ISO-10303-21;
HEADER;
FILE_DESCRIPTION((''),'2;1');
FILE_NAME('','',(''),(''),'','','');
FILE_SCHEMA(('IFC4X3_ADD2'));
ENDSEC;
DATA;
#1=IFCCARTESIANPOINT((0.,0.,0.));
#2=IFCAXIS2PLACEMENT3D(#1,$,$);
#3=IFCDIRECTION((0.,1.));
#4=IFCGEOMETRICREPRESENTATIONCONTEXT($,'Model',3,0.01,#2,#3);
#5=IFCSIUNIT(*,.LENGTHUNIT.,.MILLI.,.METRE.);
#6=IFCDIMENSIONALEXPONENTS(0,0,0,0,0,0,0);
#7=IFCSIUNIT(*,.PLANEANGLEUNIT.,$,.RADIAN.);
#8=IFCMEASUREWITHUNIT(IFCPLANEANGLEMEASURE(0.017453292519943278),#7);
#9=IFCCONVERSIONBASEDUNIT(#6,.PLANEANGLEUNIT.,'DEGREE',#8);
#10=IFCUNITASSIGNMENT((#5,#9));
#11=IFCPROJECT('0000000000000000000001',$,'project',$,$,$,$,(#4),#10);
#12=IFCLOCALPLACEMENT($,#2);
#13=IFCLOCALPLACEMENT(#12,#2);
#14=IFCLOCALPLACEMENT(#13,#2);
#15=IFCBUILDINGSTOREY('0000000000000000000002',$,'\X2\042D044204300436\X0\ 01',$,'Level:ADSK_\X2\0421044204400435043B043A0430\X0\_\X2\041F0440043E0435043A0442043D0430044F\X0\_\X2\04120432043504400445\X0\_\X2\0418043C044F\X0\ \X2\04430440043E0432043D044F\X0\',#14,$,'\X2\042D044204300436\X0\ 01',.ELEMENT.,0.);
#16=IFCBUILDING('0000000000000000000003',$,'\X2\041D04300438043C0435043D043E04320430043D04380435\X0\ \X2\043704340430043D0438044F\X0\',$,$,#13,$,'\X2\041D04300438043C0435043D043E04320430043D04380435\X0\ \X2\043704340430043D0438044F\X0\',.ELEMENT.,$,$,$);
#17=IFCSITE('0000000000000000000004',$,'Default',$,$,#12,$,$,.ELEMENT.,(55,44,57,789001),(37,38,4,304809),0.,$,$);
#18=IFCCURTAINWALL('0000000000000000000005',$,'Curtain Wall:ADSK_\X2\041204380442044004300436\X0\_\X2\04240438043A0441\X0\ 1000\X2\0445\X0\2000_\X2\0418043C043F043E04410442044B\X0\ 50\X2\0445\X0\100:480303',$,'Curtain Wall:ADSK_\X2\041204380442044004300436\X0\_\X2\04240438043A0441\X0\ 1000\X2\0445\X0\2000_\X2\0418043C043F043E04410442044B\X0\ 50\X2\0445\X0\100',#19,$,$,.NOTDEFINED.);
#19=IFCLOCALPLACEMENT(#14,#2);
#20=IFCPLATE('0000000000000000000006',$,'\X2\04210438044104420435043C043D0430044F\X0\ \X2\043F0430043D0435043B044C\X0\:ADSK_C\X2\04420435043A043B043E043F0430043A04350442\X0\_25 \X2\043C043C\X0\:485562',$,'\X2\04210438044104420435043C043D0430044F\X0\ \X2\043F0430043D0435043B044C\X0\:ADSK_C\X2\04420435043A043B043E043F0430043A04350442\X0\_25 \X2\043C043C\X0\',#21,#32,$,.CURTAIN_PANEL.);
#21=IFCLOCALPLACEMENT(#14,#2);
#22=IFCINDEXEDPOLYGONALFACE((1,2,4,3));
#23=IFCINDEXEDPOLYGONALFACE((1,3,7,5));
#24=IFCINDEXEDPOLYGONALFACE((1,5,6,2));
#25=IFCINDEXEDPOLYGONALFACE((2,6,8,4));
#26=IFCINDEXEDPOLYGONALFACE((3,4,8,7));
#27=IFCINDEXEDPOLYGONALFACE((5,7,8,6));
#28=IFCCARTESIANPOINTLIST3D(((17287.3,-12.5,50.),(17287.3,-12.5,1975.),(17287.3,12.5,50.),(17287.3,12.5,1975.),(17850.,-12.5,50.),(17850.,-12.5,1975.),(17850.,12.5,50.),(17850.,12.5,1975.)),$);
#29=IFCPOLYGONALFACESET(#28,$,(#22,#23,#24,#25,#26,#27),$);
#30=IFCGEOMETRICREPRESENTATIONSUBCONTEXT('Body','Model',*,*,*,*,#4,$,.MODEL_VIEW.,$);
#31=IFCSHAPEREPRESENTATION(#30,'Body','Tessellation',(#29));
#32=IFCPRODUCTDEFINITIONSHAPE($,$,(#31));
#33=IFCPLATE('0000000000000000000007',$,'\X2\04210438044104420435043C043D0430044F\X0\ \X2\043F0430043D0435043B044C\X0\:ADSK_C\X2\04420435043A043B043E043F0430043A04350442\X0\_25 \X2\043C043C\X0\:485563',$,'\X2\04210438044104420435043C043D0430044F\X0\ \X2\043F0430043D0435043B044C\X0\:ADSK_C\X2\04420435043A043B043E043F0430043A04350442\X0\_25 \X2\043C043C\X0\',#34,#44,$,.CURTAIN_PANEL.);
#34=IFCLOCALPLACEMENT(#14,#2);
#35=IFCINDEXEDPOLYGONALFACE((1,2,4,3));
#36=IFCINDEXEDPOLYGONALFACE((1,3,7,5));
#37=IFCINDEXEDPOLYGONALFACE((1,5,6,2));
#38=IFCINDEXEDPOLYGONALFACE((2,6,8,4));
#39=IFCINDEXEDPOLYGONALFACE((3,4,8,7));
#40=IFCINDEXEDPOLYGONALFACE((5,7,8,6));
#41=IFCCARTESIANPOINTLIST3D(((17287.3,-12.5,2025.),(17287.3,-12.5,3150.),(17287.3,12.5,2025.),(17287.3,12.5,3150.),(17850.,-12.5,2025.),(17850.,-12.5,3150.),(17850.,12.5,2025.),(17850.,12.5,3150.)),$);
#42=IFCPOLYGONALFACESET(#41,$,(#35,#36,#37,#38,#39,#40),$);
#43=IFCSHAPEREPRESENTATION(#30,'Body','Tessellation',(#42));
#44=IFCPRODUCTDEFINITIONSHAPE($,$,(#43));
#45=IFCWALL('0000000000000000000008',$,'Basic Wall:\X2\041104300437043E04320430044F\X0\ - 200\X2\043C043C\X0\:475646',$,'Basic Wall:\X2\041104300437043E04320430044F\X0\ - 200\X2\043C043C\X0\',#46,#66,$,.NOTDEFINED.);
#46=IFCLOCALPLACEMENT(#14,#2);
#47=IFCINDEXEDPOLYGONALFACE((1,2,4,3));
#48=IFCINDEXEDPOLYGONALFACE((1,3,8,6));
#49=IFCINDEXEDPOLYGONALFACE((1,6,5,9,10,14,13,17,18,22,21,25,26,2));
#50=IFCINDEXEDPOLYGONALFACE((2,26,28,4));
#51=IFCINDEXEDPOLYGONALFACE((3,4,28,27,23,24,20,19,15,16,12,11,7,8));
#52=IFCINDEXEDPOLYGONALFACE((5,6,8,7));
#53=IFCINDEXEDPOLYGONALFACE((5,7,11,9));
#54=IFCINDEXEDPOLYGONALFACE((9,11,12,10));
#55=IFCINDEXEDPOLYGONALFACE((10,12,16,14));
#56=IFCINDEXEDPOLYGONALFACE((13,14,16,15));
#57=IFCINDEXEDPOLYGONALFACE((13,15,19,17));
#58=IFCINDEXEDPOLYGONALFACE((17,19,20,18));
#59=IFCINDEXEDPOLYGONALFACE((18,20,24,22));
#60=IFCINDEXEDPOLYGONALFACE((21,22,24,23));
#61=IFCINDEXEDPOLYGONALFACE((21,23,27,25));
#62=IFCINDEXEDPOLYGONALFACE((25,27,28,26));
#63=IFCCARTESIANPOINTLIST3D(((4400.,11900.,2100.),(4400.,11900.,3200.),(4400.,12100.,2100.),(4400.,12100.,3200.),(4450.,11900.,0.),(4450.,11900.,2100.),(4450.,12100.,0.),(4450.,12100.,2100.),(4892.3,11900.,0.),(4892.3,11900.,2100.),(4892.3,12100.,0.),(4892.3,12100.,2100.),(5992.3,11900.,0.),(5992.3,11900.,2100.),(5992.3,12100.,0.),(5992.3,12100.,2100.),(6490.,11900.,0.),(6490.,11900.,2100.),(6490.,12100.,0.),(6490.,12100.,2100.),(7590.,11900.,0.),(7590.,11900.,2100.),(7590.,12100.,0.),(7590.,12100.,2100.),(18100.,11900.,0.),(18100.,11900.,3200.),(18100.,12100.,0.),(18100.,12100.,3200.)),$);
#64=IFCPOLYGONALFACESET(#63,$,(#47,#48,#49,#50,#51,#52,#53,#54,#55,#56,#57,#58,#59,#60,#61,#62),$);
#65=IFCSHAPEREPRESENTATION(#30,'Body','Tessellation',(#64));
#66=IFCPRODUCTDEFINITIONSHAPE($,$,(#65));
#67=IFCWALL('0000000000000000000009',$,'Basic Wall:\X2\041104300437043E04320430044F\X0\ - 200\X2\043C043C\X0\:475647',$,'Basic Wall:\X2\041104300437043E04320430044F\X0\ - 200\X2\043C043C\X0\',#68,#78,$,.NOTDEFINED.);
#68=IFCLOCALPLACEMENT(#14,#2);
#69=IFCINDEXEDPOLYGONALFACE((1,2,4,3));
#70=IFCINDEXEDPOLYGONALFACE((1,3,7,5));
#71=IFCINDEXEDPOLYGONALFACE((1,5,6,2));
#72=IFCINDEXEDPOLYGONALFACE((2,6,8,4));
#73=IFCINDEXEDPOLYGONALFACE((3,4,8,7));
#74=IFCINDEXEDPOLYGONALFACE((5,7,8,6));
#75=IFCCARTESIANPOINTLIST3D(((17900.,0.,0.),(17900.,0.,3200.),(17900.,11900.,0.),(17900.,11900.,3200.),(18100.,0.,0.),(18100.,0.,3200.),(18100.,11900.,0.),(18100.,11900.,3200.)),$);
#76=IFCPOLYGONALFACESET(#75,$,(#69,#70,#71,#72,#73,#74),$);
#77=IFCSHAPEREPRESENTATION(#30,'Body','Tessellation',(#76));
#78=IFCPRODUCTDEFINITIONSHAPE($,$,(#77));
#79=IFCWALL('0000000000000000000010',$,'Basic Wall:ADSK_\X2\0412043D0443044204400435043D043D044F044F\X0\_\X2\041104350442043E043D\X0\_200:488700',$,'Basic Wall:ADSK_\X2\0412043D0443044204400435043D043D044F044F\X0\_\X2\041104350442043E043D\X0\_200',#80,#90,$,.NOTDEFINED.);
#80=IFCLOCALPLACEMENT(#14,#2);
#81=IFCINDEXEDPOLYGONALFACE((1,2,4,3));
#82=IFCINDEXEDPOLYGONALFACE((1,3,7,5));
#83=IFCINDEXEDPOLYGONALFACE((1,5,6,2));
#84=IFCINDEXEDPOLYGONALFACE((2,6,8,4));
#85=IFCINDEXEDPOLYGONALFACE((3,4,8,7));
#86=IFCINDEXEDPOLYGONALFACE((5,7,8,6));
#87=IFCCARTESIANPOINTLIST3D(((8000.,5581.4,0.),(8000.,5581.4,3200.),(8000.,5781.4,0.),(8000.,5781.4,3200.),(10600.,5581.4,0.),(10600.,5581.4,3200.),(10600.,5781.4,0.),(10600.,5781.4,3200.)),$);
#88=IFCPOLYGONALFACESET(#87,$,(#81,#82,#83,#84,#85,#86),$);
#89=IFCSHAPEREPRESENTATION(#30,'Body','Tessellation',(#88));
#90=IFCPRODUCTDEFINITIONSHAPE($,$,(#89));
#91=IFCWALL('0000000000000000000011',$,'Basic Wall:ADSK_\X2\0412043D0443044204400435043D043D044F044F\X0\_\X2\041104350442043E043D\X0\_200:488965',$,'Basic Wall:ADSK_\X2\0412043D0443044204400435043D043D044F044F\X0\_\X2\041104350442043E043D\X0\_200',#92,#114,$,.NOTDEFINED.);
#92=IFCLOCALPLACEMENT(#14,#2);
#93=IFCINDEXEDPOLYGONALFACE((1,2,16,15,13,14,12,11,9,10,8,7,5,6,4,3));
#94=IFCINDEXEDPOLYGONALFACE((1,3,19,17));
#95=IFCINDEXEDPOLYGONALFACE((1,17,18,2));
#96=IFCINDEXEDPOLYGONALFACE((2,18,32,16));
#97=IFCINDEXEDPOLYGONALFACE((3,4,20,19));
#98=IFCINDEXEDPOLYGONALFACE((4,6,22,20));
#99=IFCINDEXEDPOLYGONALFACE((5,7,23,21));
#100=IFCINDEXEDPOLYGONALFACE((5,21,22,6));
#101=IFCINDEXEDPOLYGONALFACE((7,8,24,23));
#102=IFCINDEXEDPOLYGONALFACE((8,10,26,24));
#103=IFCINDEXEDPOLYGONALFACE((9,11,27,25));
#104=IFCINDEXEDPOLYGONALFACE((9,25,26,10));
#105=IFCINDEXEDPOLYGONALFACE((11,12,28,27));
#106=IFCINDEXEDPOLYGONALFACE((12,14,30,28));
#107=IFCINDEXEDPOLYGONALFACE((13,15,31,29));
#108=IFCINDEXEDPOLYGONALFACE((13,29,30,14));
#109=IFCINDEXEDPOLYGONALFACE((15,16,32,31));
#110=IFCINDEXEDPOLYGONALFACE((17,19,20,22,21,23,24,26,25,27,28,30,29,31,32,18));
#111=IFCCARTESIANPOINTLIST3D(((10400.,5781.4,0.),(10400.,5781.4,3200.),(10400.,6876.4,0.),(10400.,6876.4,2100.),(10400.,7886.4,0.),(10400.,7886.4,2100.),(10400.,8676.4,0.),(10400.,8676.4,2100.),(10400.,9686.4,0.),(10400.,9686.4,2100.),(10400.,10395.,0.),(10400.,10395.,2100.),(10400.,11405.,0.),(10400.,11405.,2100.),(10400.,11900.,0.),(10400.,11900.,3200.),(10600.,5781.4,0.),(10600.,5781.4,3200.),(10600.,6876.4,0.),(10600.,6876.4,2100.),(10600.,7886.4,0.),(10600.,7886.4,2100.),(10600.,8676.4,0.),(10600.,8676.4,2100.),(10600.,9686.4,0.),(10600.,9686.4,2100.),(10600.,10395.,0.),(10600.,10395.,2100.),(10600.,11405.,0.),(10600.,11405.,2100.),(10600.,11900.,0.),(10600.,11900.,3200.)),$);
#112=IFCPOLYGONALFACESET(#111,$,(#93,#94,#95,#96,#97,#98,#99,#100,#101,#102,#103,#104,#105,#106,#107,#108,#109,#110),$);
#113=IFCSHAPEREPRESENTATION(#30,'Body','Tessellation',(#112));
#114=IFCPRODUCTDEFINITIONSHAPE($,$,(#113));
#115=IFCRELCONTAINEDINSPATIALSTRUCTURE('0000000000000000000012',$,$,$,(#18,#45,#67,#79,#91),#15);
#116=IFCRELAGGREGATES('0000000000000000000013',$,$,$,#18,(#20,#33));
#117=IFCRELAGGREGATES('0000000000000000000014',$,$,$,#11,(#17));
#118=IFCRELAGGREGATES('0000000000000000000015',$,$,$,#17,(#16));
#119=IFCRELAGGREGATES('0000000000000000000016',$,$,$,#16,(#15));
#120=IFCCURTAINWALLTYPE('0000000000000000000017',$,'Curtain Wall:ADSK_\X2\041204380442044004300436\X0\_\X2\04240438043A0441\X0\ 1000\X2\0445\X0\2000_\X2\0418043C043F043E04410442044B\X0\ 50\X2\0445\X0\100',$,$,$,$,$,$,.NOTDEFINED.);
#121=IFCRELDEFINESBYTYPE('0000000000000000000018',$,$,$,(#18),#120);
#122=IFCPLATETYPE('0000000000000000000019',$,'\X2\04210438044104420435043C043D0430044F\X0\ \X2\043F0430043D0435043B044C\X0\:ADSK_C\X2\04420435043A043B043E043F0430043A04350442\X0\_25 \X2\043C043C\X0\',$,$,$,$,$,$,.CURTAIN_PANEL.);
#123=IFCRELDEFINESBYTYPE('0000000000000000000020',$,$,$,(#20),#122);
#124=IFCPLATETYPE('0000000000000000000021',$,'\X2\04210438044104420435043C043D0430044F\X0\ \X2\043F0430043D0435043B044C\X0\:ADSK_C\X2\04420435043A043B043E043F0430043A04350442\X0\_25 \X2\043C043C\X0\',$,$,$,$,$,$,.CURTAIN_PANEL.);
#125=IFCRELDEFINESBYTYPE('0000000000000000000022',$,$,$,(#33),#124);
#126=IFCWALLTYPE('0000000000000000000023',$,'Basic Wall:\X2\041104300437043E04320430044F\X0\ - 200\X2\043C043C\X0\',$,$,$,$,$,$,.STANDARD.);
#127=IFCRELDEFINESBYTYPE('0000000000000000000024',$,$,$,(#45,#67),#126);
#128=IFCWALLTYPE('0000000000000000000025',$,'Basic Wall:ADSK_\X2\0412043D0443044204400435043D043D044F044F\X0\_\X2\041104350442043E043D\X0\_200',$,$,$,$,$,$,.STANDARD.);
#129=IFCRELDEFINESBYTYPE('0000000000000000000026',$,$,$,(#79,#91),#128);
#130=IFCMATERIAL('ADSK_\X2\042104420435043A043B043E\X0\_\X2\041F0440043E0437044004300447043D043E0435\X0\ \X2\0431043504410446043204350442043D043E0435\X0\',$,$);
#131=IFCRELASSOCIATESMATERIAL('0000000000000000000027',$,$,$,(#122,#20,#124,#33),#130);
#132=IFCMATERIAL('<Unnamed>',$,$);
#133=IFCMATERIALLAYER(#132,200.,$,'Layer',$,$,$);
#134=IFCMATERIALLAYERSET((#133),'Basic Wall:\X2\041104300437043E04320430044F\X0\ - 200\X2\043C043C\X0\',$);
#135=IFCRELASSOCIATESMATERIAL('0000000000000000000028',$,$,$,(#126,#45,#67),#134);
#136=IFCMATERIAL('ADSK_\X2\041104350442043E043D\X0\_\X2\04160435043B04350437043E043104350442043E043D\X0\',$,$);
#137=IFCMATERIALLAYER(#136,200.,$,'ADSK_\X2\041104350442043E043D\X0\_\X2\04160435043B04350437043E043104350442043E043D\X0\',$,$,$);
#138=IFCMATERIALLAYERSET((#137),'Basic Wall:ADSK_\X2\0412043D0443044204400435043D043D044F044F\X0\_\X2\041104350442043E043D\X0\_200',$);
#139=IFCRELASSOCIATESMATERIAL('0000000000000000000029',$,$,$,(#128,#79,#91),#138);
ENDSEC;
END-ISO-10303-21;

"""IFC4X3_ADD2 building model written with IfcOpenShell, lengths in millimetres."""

from ifc_helpers import new_model, entity, si_unit, converted_unit, direction, frame, frame_2d, origin, origin_2d_with_axis, place, context, subcontext, project, spatial, rectangle, extrude, source, transform, mapped, material, layer, layer_set, type_object, type_shapes, element, aggregate, save


model = new_model("IFC4X3_ADD2")

# Units and contexts
model_context = context("Model", 3, precision=0.01, world=origin(), true_north=direction((0.0, 1.0)))
body_context = subcontext(model_context, "Body", "Model", "MODEL_VIEW")
ifc_project = project(units=[si_unit("LENGTHUNIT", "METRE", prefix="MILLI"), converted_unit("PLANEANGLEUNIT", "DEGREE", entity("IfcPlaneAngleMeasure", 0.017453292519943278), si_unit("PLANEANGLEUNIT", "RADIAN"), dimensions=[0, 0, 0, 0, 0, 0, 0])], contexts=[model_context])

# Site, building, storey
site_placement = place(None, origin())
site = spatial("IfcSite", under=ifc_project, at=site_placement, Name="Default", CompositionType="ELEMENT", RefLatitude=(55, 44, 57, 789001), RefLongitude=(37, 38, 4, 304809), RefElevation=0.0)
building_placement = place(site_placement, origin())
building = spatial("IfcBuilding", under=site, at=building_placement, Name="Наименование здания", LongName="Наименование здания", CompositionType="ELEMENT")
storey_placement = place(building_placement, origin())
storey = spatial("IfcBuildingStorey", under=building, at=storey_placement, Name="Этаж 01", ObjectType="Level:ADSK_Стрелка_Проектная_Вверх_Имя уровня", LongName="Этаж 01", CompositionType="ELEMENT", Elevation=0.0)

# Curtain wall, plates
curtain_wall_type = type_object("IfcCurtainWallType", Name="Curtain Wall:ADSK_Витраж_Фикс 1000х2000_Импосты 50х100", PredefinedType="NOTDEFINED")
curtain_wall_placement = place(storey_placement, origin())
curtain_wall = element("IfcCurtainWall", 1, at=curtain_wall_placement, inside=storey, type_object=curtain_wall_type, Name="Curtain Wall:ADSK_Витраж_Фикс 1000х2000_Импосты 50х100:480303", ObjectType="Curtain Wall:ADSK_Витраж_Фикс 1000х2000_Импосты 50х100", PredefinedType="NOTDEFINED")
ifc_material_1 = material(Name="ADSK_Стекло_Прозрачное бесцветное")
plate_type_1 = type_object("IfcPlateType", Name="Системная панель:ADSK_Cтеклопакет_25 мм", PredefinedType="CURTAIN_PANEL", material=ifc_material_1)
shared_shape_1 = source(origin(), body_context, "Body", "SweptSolid", [
    extrude(rectangle(XDim=25.0, YDim=562.7, at=origin_2d_with_axis()), frame((0.0, 0.0, 0.0), z_axis=(0.0, 0.0, 1.0), x_axis=(0.0, 1.0, 0.0)), (0.0, 0.0, 1.0), 1925.0),
])
type_shapes(plate_type_1, [shared_shape_1])
plate_1_placement = place(curtain_wall_placement, frame((17568.6, 0.0, 50.0)))
plate_1 = element("IfcPlate", 2, at=plate_1_placement, type_object=plate_type_1, material=ifc_material_1, Name="Системная панель:ADSK_Cтеклопакет_25 мм:485562", ObjectType="Системная панель:ADSK_Cтеклопакет_25 мм", PredefinedType="CURTAIN_PANEL", context=body_context, shape_type="MappedRepresentation", body=[
    mapped(shared_shape_1, transform((0.0, 0.0, 0.0), scale=1.0)),
])
plate_type_2 = type_object("IfcPlateType", Name="Системная панель:ADSK_Cтеклопакет_25 мм", PredefinedType="CURTAIN_PANEL", material=ifc_material_1)
shared_shape_2 = source(origin(), body_context, "Body", "SweptSolid", [
    extrude(rectangle(XDim=25.0, YDim=562.7, at=origin_2d_with_axis()), frame((0.0, 0.0, 0.0), z_axis=(0.0, 0.0, 1.0), x_axis=(0.0, 1.0, 0.0)), (0.0, 0.0, 1.0), 1125.0),
])
type_shapes(plate_type_2, [shared_shape_2])
plate_2_placement = place(curtain_wall_placement, frame((17568.6, 0.0, 2025.0)))
plate_2 = element("IfcPlate", 3, at=plate_2_placement, type_object=plate_type_2, material=ifc_material_1, Name="Системная панель:ADSK_Cтеклопакет_25 мм:485563", ObjectType="Системная панель:ADSK_Cтеклопакет_25 мм", PredefinedType="CURTAIN_PANEL", context=body_context, shape_type="MappedRepresentation", body=[
    mapped(shared_shape_2, transform((0.0, 0.0, 0.0), scale=1.0)),
])
aggregate(curtain_wall, [plate_1, plate_2])

# Wall, openings
ifc_material_2 = material(Name="<Unnamed>")
ifc_layer_1 = layer(ifc_material_2, 200.0, Name="Layer")
ifc_layer_set_1 = layer_set([ifc_layer_1], Name="Basic Wall:Базовая - 200мм")
wall_type_1 = type_object("IfcWallType", Name="Basic Wall:Базовая - 200мм", PredefinedType="STANDARD", material=ifc_layer_set_1)
wall_1_placement = place(storey_placement, frame((18100.0, 12000.0, 0.0), z_axis=(0.0, 0.0, 1.0), x_axis=(-1.0, 0.0, 0.0)))
wall_1 = element("IfcWall", 4, at=wall_1_placement, inside=storey, type_object=wall_type_1, material=ifc_layer_set_1, Name="Basic Wall:Базовая - 200мм:475646", ObjectType="Basic Wall:Базовая - 200мм", PredefinedType="NOTDEFINED", context=body_context, shape_type="SweptSolid", body=[
    extrude(rectangle(XDim=13700.0, YDim=200.0, at=frame_2d((6850.0, 0.0), x_axis=(-1.0, 0.0))), origin(), (0.0, 0.0, 1.0), 3200.0),
])
opening_1_placement = place(wall_1_placement, frame((18100.0, 12000.0, 0.0)))
element("IfcOpeningElement", 5, at=opening_1_placement, cuts=wall_1, PredefinedType="OPENING", context=body_context, shape_type="SweptSolid", body=[
    extrude(rectangle(XDim=2100.0, YDim=1100.0, at=frame_2d((0.0, 0.0), x_axis=(0.0, 1.0))), frame((-3900.0, -12600.0, 1050.0), z_axis=(0.0, 1.0, 0.0), x_axis=(1.0, 0.0, 0.0)), (0.0, 0.0, 1.0), 1200.0),
])
opening_2_placement = place(wall_1_placement, frame((18100.0, 12000.0, 0.0), z_axis=(0.0, 0.0, 1.0), x_axis=(-1.0, 0.0, 0.0)))
element("IfcOpeningElement", 6, at=opening_2_placement, cuts=wall_1, PredefinedType="OPENING", context=body_context, shape_type="SweptSolid", body=[
    extrude(rectangle(XDim=2100.0, YDim=1100.0, at=frame_2d((0.0, 0.0), x_axis=(0.0, 1.0))), frame((7040.0, 12600.0, 1050.0), z_axis=(0.0, -1.0, 0.0), x_axis=(-1.0, 0.0, 0.0)), (0.0, 0.0, 1.0), 1200.0),
])
opening_3_placement = place(wall_1_placement, frame((18100.0, 12000.0, 0.0), z_axis=(0.0, 0.0, 1.0), x_axis=(-1.0, 0.0, 0.0)))
element("IfcOpeningElement", 7, at=opening_3_placement, cuts=wall_1, PredefinedType="OPENING", context=body_context, shape_type="SweptSolid", body=[
    extrude(rectangle(XDim=2100.0, YDim=1100.0, at=frame_2d((0.0, 0.0), x_axis=(0.0, 1.0))), frame((5442.3, 12600.0, 1050.0), z_axis=(0.0, -1.0, 0.0), x_axis=(-1.0, 0.0, 0.0)), (0.0, 0.0, 1.0), 1200.0),
])

# Walls
wall_2_placement = place(storey_placement, frame((18000.0, 0.0, 0.0), z_axis=(0.0, 0.0, 1.0), x_axis=(0.0, 1.0, 0.0)))
element("IfcWall", 8, at=wall_2_placement, inside=storey, type_object=wall_type_1, material=ifc_layer_set_1, Name="Basic Wall:Базовая - 200мм:475647", ObjectType="Basic Wall:Базовая - 200мм", PredefinedType="NOTDEFINED", context=body_context, shape_type="SweptSolid", body=[
    extrude(rectangle(XDim=11900.0, YDim=200.0, at=frame_2d((5950.0, 0.0), x_axis=(-1.0, 0.0))), origin(), (0.0, 0.0, 1.0), 3200.0),
])
ifc_material_3 = material(Name="ADSK_Бетон_Железобетон")
ifc_layer_2 = layer(ifc_material_3, 200.0, Name="ADSK_Бетон_Железобетон")
ifc_layer_set_2 = layer_set([ifc_layer_2], Name="Basic Wall:ADSK_Внутренняя_Бетон_200")
wall_type_2 = type_object("IfcWallType", Name="Basic Wall:ADSK_Внутренняя_Бетон_200", PredefinedType="STANDARD", material=ifc_layer_set_2)
wall_3_placement = place(storey_placement, frame((8000.0, 5681.4, 0.0)))
element("IfcWall", 9, at=wall_3_placement, inside=storey, type_object=wall_type_2, material=ifc_layer_set_2, Name="Basic Wall:ADSK_Внутренняя_Бетон_200:488700", ObjectType="Basic Wall:ADSK_Внутренняя_Бетон_200", PredefinedType="NOTDEFINED", context=body_context, shape_type="SweptSolid", body=[
    extrude(rectangle(XDim=2600.0, YDim=200.0, at=frame_2d((1300.0, 0.0), x_axis=(-1.0, 0.0))), origin(), (0.0, 0.0, 1.0), 3200.0),
])

# Wall, openings
wall_4_placement = place(storey_placement, frame((10500.0, 5781.4, 0.0), z_axis=(0.0, 0.0, 1.0), x_axis=(0.0, 1.0, 0.0)))
wall_4 = element("IfcWall", 10, at=wall_4_placement, inside=storey, type_object=wall_type_2, material=ifc_layer_set_2, Name="Basic Wall:ADSK_Внутренняя_Бетон_200:488965", ObjectType="Basic Wall:ADSK_Внутренняя_Бетон_200", PredefinedType="NOTDEFINED", context=body_context, shape_type="SweptSolid", body=[
    extrude(rectangle(XDim=6118.6, YDim=200.0, at=frame_2d((3059.3, 0.0), x_axis=(-1.0, 0.0))), origin(), (0.0, 0.0, 1.0), 3200.0),
])
opening_4_placement = place(wall_4_placement, frame((-5781.4, 10500.0, 0.0), z_axis=(0.0, 0.0, 1.0), x_axis=(0.0, -1.0, 0.0)))
element("IfcOpeningElement", 11, at=opening_4_placement, cuts=wall_4, PredefinedType="OPENING", context=body_context, shape_type="SweptSolid", body=[
    extrude(rectangle(XDim=2100.0, YDim=1010.0, at=frame_2d((0.0, 0.0), x_axis=(1.0, 0.0))), frame((10600.0, 7381.4, 1050.0), z_axis=(-1.0, 0.0, 0.0), x_axis=(0.0, 0.0, -1.0)), (0.0, 0.0, 1.0), 200.0),
])
opening_5_placement = place(wall_4_placement, frame((-5781.4, 10500.0, 0.0), z_axis=(0.0, 0.0, 1.0), x_axis=(0.0, -1.0, 0.0)))
element("IfcOpeningElement", 12, at=opening_5_placement, cuts=wall_4, PredefinedType="OPENING", context=body_context, shape_type="SweptSolid", body=[
    extrude(rectangle(XDim=2100.0, YDim=1010.0, at=frame_2d((0.0, 0.0), x_axis=(1.0, 0.0))), frame((10600.0, 9181.4, 1050.0), z_axis=(-1.0, 0.0, 0.0), x_axis=(0.0, 0.0, -1.0)), (0.0, 0.0, 1.0), 200.0),
])
opening_6_placement = place(wall_4_placement, frame((-5781.4, 10500.0, 0.0), z_axis=(0.0, 0.0, 1.0), x_axis=(0.0, -1.0, 0.0)))
element("IfcOpeningElement", 13, at=opening_6_placement, cuts=wall_4, PredefinedType="OPENING", context=body_context, shape_type="SweptSolid", body=[
    extrude(rectangle(XDim=2100.0, YDim=1010.0, at=origin_2d_with_axis()), frame((10600.0, 10900.0, 1050.0), z_axis=(-1.0, 0.0, 0.0), x_axis=(0.0, 0.0, -1.0)), (0.0, 0.0, 1.0), 200.0),
])

save(model, "model.ifc")
